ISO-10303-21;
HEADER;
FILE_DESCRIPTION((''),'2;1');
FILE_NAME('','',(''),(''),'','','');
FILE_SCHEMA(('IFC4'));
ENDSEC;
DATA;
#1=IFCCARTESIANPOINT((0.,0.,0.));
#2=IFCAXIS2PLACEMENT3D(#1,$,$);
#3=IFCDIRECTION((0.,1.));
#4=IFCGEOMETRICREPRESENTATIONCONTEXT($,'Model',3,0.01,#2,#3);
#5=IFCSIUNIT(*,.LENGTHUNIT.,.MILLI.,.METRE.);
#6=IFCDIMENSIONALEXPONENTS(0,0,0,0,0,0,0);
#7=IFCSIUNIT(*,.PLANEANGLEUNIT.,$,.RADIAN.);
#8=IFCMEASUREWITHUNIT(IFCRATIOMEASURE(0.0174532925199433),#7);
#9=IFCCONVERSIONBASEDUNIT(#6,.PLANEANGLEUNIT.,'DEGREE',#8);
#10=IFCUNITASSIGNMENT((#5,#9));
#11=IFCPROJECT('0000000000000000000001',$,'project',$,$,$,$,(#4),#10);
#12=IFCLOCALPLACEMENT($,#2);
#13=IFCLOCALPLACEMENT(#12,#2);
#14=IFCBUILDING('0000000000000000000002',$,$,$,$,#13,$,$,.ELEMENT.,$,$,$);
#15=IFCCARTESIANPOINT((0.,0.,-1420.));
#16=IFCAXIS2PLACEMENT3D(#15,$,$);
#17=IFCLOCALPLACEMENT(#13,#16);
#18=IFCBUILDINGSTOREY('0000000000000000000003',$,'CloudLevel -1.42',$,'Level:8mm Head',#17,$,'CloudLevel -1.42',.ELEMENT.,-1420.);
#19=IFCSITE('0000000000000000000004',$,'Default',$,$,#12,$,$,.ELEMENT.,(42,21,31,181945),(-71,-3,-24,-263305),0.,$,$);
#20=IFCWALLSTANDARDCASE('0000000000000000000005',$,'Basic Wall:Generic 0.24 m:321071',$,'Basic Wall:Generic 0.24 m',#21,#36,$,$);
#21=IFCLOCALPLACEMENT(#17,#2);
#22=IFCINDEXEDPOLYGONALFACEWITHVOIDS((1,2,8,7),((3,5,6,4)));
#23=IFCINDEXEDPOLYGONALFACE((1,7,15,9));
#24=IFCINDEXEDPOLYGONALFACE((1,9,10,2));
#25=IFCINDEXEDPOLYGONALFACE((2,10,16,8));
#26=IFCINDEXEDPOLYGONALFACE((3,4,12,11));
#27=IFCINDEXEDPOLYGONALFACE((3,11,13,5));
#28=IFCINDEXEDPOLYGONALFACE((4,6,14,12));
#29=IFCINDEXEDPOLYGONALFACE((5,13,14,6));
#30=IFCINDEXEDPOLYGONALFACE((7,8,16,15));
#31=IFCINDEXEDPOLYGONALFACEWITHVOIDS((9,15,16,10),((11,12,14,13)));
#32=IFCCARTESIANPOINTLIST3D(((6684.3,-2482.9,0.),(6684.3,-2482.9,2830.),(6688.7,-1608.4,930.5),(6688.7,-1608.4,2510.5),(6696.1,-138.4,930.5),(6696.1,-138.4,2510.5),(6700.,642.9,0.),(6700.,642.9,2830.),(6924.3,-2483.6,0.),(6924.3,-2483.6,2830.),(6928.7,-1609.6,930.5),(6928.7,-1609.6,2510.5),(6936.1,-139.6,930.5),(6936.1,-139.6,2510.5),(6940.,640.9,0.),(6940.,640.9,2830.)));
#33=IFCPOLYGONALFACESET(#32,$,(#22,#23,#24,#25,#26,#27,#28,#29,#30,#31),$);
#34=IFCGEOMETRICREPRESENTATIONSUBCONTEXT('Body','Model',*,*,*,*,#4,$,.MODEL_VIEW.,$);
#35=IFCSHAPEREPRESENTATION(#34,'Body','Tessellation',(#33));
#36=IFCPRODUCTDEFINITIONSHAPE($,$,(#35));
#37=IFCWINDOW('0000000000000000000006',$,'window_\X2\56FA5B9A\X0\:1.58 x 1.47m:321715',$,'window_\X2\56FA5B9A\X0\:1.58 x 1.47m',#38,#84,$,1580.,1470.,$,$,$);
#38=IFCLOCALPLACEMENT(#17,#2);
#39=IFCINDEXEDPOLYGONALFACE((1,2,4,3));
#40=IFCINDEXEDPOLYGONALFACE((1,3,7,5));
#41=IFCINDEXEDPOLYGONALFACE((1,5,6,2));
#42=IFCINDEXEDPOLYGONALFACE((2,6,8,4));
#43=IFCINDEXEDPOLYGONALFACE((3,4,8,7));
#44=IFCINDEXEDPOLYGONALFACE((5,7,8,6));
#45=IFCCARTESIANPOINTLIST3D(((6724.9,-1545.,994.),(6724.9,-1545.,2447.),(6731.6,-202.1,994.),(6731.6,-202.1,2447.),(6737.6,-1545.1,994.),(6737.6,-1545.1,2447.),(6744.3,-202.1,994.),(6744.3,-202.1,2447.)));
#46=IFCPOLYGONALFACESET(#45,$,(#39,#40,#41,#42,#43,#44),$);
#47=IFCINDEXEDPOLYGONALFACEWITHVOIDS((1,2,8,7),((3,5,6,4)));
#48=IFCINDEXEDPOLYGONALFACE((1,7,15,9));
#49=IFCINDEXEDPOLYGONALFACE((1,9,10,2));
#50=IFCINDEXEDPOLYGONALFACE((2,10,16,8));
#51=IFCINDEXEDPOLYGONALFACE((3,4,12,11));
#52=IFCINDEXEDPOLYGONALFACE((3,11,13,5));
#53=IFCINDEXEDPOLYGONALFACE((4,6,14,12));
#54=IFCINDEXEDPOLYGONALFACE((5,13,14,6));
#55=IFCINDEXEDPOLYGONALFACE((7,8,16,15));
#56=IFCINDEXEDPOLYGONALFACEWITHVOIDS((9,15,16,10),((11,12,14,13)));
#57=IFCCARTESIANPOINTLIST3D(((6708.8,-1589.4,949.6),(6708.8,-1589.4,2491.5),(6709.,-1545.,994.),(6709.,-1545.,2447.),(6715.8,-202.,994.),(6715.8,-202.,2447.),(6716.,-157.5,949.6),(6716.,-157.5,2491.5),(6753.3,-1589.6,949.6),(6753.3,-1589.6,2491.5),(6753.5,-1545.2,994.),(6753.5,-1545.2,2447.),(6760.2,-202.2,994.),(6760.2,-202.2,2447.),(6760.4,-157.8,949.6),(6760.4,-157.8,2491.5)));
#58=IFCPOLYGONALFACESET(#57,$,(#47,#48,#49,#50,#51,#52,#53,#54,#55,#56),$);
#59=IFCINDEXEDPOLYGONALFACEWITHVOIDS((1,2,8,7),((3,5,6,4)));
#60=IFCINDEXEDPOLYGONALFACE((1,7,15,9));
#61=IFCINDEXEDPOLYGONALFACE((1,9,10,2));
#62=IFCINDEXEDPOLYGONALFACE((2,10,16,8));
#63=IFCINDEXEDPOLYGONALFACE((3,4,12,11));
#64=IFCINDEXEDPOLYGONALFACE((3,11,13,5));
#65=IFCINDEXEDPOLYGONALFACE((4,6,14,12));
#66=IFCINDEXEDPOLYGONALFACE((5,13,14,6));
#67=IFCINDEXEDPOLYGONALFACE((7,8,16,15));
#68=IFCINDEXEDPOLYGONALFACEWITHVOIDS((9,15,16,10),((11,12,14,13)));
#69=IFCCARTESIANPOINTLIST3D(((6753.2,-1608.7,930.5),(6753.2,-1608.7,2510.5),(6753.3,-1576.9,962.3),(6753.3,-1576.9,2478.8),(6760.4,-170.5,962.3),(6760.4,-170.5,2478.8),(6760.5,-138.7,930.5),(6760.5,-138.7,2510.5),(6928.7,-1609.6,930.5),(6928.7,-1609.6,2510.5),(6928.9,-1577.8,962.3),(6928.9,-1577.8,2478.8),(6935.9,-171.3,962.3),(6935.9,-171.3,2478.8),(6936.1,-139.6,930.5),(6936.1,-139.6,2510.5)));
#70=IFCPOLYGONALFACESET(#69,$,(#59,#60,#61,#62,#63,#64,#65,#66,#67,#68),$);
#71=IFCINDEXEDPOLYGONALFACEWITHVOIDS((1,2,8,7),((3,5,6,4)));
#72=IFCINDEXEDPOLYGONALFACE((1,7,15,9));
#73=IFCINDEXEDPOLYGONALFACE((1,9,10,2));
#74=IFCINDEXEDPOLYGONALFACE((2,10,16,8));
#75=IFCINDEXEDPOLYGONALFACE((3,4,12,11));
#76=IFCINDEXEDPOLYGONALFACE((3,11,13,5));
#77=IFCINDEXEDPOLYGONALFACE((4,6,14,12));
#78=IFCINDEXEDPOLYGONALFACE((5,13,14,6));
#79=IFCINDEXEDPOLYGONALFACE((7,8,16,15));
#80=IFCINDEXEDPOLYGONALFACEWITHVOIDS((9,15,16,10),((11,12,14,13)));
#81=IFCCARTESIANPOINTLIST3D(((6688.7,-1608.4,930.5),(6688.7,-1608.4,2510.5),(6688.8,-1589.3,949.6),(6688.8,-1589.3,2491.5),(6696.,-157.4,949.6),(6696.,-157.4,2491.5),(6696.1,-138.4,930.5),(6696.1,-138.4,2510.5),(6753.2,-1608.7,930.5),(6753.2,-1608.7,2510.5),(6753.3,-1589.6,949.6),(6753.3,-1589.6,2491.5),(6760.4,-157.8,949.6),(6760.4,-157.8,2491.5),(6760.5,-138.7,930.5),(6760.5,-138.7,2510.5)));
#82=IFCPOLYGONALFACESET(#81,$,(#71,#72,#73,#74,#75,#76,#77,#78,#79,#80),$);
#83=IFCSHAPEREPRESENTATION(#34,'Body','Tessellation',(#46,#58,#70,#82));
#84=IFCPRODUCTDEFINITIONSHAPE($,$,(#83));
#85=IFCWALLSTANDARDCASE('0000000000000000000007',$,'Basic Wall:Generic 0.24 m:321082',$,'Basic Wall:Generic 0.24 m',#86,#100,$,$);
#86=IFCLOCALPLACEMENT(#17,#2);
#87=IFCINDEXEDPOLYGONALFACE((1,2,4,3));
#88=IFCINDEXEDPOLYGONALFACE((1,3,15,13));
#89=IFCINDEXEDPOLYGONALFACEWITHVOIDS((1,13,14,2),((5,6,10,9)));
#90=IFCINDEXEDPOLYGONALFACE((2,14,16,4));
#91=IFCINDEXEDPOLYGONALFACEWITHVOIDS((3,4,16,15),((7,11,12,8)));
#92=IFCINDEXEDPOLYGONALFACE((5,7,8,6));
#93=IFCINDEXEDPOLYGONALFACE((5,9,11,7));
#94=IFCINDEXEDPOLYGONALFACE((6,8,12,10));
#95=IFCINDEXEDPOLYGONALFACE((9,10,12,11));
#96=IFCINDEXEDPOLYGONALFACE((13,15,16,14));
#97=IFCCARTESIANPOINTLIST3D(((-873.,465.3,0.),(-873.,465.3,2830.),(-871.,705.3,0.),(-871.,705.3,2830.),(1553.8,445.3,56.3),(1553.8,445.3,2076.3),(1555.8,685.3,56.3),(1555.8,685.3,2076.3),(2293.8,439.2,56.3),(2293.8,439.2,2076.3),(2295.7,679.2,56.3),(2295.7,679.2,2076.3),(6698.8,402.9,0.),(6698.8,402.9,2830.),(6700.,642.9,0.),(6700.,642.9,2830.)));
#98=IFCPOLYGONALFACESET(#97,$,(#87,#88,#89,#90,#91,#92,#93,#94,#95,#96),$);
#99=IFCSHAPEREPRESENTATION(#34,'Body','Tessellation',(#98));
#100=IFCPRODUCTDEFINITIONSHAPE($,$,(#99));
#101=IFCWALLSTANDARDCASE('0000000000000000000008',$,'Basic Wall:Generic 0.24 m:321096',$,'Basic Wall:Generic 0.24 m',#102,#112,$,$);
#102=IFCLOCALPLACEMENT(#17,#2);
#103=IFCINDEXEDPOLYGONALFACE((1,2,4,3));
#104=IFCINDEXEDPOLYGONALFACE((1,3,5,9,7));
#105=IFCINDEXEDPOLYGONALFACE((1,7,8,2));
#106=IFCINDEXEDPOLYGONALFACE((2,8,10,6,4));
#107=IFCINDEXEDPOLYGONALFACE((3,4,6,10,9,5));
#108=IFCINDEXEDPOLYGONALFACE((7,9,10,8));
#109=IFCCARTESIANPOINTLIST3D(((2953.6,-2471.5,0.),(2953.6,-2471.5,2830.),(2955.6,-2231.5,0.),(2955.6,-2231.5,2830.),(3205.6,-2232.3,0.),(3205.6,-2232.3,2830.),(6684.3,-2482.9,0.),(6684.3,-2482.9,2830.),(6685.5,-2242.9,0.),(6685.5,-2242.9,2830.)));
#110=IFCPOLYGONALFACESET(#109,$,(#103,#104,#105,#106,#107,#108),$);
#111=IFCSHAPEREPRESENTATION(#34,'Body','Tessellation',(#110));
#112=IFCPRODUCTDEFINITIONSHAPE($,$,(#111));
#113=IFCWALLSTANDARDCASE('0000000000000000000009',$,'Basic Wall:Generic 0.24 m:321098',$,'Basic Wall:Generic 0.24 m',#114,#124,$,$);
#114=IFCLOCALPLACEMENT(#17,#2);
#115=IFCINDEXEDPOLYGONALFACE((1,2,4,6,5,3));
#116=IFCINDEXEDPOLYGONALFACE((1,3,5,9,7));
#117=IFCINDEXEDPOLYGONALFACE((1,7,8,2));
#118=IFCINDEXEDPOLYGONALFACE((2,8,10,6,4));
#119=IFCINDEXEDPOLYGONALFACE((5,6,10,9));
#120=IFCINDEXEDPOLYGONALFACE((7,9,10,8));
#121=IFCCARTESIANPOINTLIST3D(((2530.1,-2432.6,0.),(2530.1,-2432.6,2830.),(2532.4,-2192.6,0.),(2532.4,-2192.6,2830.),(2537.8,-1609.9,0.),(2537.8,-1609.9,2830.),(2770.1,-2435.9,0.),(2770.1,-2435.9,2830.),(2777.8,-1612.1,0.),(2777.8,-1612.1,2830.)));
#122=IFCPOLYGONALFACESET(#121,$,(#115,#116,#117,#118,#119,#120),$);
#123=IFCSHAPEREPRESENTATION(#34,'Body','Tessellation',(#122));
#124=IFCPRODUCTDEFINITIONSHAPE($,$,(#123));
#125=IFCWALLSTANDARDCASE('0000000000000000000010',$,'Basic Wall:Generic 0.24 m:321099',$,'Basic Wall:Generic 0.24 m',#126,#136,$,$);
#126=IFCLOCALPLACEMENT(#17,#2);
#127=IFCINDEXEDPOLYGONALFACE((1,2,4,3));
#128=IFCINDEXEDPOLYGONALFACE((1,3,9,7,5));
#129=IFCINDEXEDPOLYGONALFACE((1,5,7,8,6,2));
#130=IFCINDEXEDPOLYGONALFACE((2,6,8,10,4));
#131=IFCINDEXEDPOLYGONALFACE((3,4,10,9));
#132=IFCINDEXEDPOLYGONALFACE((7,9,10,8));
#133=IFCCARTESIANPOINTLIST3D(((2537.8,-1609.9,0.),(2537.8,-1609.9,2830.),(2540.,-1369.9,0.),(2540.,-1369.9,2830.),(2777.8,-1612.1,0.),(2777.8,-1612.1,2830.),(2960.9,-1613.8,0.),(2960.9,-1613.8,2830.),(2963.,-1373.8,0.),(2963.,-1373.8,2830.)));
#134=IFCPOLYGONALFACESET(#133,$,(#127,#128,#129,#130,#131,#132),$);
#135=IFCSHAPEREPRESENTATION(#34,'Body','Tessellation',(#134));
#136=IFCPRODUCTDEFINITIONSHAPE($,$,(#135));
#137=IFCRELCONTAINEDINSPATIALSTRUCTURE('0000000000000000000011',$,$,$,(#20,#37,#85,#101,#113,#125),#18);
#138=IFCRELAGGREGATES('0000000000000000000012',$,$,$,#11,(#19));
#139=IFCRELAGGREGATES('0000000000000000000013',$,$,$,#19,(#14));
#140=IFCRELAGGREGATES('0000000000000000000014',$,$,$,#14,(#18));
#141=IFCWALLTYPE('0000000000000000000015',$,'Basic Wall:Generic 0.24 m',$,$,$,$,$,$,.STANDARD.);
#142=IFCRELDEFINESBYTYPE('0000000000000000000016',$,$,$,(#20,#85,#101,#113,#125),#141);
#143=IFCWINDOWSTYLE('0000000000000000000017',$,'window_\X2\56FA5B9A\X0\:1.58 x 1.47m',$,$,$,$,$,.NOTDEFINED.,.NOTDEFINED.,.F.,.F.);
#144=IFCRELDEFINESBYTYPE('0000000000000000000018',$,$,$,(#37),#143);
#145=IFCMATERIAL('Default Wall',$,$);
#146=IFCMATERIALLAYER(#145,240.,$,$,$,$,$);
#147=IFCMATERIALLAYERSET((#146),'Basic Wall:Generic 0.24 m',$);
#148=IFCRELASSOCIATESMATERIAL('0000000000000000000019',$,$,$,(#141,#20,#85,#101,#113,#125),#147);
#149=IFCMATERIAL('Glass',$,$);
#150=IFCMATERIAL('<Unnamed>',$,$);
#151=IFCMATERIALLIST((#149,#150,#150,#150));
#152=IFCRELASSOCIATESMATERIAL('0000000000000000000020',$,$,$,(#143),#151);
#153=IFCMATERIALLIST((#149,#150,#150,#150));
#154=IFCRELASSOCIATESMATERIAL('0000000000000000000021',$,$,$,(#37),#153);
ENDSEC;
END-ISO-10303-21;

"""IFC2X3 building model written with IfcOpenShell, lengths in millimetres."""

from ifc_helpers import new_model, entity, si_unit, converted_unit, direction, frame, frame_2d, origin, place, context, subcontext, project, spatial, polyline, rectangle, outline, extrude, source, transform, mapped, material, material_list, layer, layer_set, layer_usage, type_object, type_shapes, element, fill, save


model = new_model("IFC2X3")

# Units and contexts
model_context = context("Model", 3, precision=0.01, world=origin(), true_north=direction((0.0, 1.0)))
body_context = subcontext(model_context, "Body", "Model", "MODEL_VIEW")
ifc_project = project(units=[si_unit("LENGTHUNIT", "METRE", prefix="MILLI"), converted_unit("PLANEANGLEUNIT", "DEGREE", entity("IfcRatioMeasure", 0.0174532925199433), si_unit("PLANEANGLEUNIT", "RADIAN"), dimensions=[0, 0, 0, 0, 0, 0, 0])], contexts=[model_context])

# Site, building, storey
site_placement = place(None, origin())
site = spatial("IfcSite", under=ifc_project, at=site_placement, Name="Default", CompositionType="ELEMENT", RefLatitude=(42, 21, 31, 181945), RefLongitude=(-71, -3, -24, -263305), RefElevation=0.0)
building_placement = place(site_placement, origin())
building = spatial("IfcBuilding", under=site, at=building_placement, CompositionType="ELEMENT")
storey_placement = place(building_placement, frame((0.0, 0.0, -1420.0)))
storey = spatial("IfcBuildingStorey", under=building, at=storey_placement, Name="CloudLevel -1.42", ObjectType="Level:8mm Head", LongName="CloudLevel -1.42", CompositionType="ELEMENT", Elevation=-1420.0)

# Wall, opening, window
ifc_material_1 = material(Name="Default Wall")
ifc_layer_1 = layer(ifc_material_1, 240.0)
ifc_layer_set_1 = layer_set([ifc_layer_1], Name="Basic Wall:Generic 0.24 m")
ifc_layer_usage_1 = layer_usage(ifc_layer_set_1, "AXIS2", "NEGATIVE", 120.0)
wall_type_1 = type_object("IfcWallType", Name="Basic Wall:Generic 0.24 m", PredefinedType="STANDARD", material=ifc_layer_set_1)
wall_1_placement = place(storey_placement, frame((6820.0, 642.3, 0.0), z_axis=(0.0, 0.0, 1.0), x_axis=(-0.005009, -0.999987, 0.0)))
wall_1 = element("IfcWallStandardCase", 1, at=wall_1_placement, inside=storey, type_object=wall_type_1, material=ifc_layer_usage_1, Name="Basic Wall:Generic 0.24 m:321071", ObjectType="Basic Wall:Generic 0.24 m", context=body_context, shape_type="SweptSolid", body=[
    extrude(outline(polyline([(3125.8, -120.0), (3125.3, 120.0), (0.8, 120.0), (0.8, 119.4), (0.0, -120.0), (240.0, -120.0), (2885.8, -120.0), (3125.8, -120.0)])), origin(), (0.0, 0.0, 1.0), 2830.0),
])
opening_1_placement = place(wall_1_placement, frame((2251.3, 120.0, 930.5)))
opening_1 = element("IfcOpeningElement", 2, at=opening_1_placement, cuts=wall_1, ObjectType="Opening", context=body_context, shape_type="SweptSolid", body=[
    extrude(rectangle(XDim=1580.0, YDim=1470.0, at=frame_2d((790.0, 735.0), x_axis=(-1.0, 0.0))), frame((0.0, 0.0, 0.0), z_axis=(0.0, -1.0, 0.0), x_axis=(0.0, 0.0, 1.0)), (0.0, 0.0, 1.0), 240.0),
])
ifc_material_2 = material(Name="Glass")
ifc_material_3 = material(Name="<Unnamed>")
ifc_material_list_1 = material_list([ifc_material_2, ifc_material_3, ifc_material_3, ifc_material_3])
ifc_material_list_2 = material_list([ifc_material_2, ifc_material_3, ifc_material_3, ifc_material_3])
window_style_1 = type_object("IfcWindowStyle", Name="window_固定:1.58 x 1.47m", ConstructionType="NOTDEFINED", OperationType="NOTDEFINED", ParameterTakesPrecedence=False, Sizeable=False, material=ifc_material_list_2)
shared_shape_1 = source(origin(), body_context, "Body", "SweptSolid", [
    extrude(rectangle(XDim=1343.0, YDim=12.7, at=frame_2d((0.0, 0.0), x_axis=(1.0, 0.0))), frame((811.2, 197.8, 63.5)), (0.0, 0.0, 1.0), 1453.0),
    extrude(outline(polyline([(-715.9, -770.9), (715.9, -770.9), (715.9, 770.9), (-715.9, 770.9), (-715.9, -770.9)]), holes=[polyline([(-671.5, -726.5), (-671.5, 726.5), (671.5, 726.5), (671.5, -726.5), (-671.5, -726.5)])]), frame((811.2, 220.0, 790.0), z_axis=(0.0, -1.0, 0.0), x_axis=(-1.0, 0.0, 0.0)), (0.0, 0.0, 1.0), 44.5),
    extrude(outline(polyline([(-735.0, -790.0), (735.0, -790.0), (735.0, 790.0), (-735.0, 790.0), (-735.0, -790.0)]), holes=[polyline([(-703.2, -758.2), (-703.2, 758.2), (703.2, 758.2), (703.2, -758.2), (-703.2, -758.2)])]), frame((811.2, 175.5, 790.0), z_axis=(0.0, -1.0, 0.0), x_axis=(-1.0, 0.0, 0.0)), (0.0, 0.0, 1.0), 175.5),
    extrude(outline(polyline([(-790.0, -735.0), (790.0, -735.0), (790.0, 735.0), (-790.0, 735.0), (-790.0, -735.0)]), holes=[polyline([(-770.9, -715.9), (-770.9, 715.9), (770.9, 715.9), (770.9, -715.9), (-770.9, -715.9)])]), frame((811.2, 240.0, 790.0), z_axis=(0.0, -1.0, 0.0), x_axis=(0.0, 0.0, -1.0)), (0.0, 0.0, 1.0), 64.5),
])
type_shapes(window_style_1, [shared_shape_1])
window_1_placement = place(opening_1_placement, frame((76.2, 0.0, 0.0), z_axis=(0.0, 0.0, 1.0), x_axis=(-1.0, 0.0, 0.0)))
window_1 = element("IfcWindow", 3, at=window_1_placement, inside=storey, type_object=window_style_1, material=ifc_material_list_1, Name="window_固定:1.58 x 1.47m:321715", ObjectType="window_固定:1.58 x 1.47m", OverallHeight=1580.0, OverallWidth=1470.0, context=body_context, shape_type="MappedRepresentation", body=[
    mapped(shared_shape_1, transform((0.0, 0.0, 0.0), scale=1.0)),
])
fill(opening_1, window_1)

# Wall, opening
ifc_layer_usage_2 = layer_usage(ifc_layer_set_1, "AXIS2", "NEGATIVE", 120.0)
wall_2_placement = place(storey_placement, frame((6699.8, 522.9, 0.0), z_axis=(0.0, 0.0, 1.0), x_axis=(-0.999966, 0.008248, 0.0)))
wall_2 = element("IfcWallStandardCase", 4, at=wall_2_placement, inside=storey, type_object=wall_type_1, material=ifc_layer_usage_2, Name="Basic Wall:Generic 0.24 m:321082", ObjectType="Basic Wall:Generic 0.24 m", context=body_context, shape_type="SweptSolid", body=[
    extrude(outline(polyline([(7572.1, -120.0), (7572.1, 120.0), (7550.3, 120.0), (7310.3, 120.0), (5519.8, 120.0), (5259.8, 120.0), (0.0, 120.0), (0.8, -120.0), (1.4, -120.0), (7572.1, -120.0)])), origin(), (0.0, 0.0, 1.0), 2830.0),
])
opening_2_placement = place(wall_2_placement, frame((4405.2, -120.0, 56.3)))
element("IfcOpeningElement", 5, at=opening_2_placement, cuts=wall_2, ObjectType="Opening", context=body_context, shape_type="SweptSolid", body=[
    extrude(rectangle(XDim=740.0, YDim=2020.0, at=frame_2d((1010.0, 370.0), x_axis=(0.0, 1.0))), frame((0.0, 0.0, 0.0), z_axis=(0.0, 1.0, 0.0), x_axis=(0.0, 0.0, 1.0)), (0.0, 0.0, 1.0), 240.0),
])

# Walls
ifc_layer_usage_3 = layer_usage(ifc_layer_set_1, "AXIS2", "NEGATIVE", 120.0)
wall_3_placement = place(storey_placement, frame((6685.2, -2362.9, 0.0), z_axis=(0.0, 0.0, 1.0), x_axis=(-0.999995, 0.003043, 0.0)))
element("IfcWallStandardCase", 6, at=wall_3_placement, inside=storey, type_object=wall_type_1, material=ifc_layer_usage_3, Name="Basic Wall:Generic 0.24 m:321096", ObjectType="Basic Wall:Generic 0.24 m", context=body_context, shape_type="SweptSolid", body=[
    extrude(outline(polyline([(3729.9, -120.0), (3731.2, 120.0), (0.5, 120.0), (0.0, -120.0), (3479.9, -120.0), (3729.9, -120.0)])), origin(), (0.0, 0.0, 1.0), 2830.0),
])
ifc_layer_usage_4 = layer_usage(ifc_layer_set_1, "AXIS2", "NEGATIVE", 120.0)
wall_4_placement = place(storey_placement, frame((2650.1, -2434.8, 0.0), z_axis=(0.0, 0.0, 1.0), x_axis=(0.009289, 0.999957, 0.0)))
element("IfcWallStandardCase", 7, at=wall_4_placement, inside=storey, type_object=wall_type_1, material=ifc_layer_usage_4, Name="Basic Wall:Generic 0.24 m:321098", ObjectType="Basic Wall:Generic 0.24 m", context=body_context, shape_type="SweptSolid", body=[
    extrude(outline(polyline([(823.8, -120.0), (823.8, 120.0), (241.1, 120.0), (1.1, 120.0), (0.0, -120.0), (823.8, -120.0)])), origin(), (0.0, 0.0, 1.0), 2830.0),
])
ifc_layer_usage_5 = layer_usage(ifc_layer_set_1, "AXIS2", "NEGATIVE", 120.0)
wall_5_placement = place(storey_placement, frame((2538.9, -1489.9, 0.0), z_axis=(0.0, 0.0, 1.0), x_axis=(0.999958, -0.009191, 0.0)))
element("IfcWallStandardCase", 8, at=wall_5_placement, inside=storey, type_object=wall_type_1, material=ifc_layer_usage_5, Name="Basic Wall:Generic 0.24 m:321099", ObjectType="Basic Wall:Generic 0.24 m", context=body_context, shape_type="SweptSolid", body=[
    extrude(outline(polyline([(423.2, -120.0), (423.0, 120.0), (0.0, 120.0), (0.0, -120.0), (240.0, -120.0), (423.2, -120.0)])), origin(), (0.0, 0.0, 1.0), 2830.0),
])

save(model, "model.ifc")
